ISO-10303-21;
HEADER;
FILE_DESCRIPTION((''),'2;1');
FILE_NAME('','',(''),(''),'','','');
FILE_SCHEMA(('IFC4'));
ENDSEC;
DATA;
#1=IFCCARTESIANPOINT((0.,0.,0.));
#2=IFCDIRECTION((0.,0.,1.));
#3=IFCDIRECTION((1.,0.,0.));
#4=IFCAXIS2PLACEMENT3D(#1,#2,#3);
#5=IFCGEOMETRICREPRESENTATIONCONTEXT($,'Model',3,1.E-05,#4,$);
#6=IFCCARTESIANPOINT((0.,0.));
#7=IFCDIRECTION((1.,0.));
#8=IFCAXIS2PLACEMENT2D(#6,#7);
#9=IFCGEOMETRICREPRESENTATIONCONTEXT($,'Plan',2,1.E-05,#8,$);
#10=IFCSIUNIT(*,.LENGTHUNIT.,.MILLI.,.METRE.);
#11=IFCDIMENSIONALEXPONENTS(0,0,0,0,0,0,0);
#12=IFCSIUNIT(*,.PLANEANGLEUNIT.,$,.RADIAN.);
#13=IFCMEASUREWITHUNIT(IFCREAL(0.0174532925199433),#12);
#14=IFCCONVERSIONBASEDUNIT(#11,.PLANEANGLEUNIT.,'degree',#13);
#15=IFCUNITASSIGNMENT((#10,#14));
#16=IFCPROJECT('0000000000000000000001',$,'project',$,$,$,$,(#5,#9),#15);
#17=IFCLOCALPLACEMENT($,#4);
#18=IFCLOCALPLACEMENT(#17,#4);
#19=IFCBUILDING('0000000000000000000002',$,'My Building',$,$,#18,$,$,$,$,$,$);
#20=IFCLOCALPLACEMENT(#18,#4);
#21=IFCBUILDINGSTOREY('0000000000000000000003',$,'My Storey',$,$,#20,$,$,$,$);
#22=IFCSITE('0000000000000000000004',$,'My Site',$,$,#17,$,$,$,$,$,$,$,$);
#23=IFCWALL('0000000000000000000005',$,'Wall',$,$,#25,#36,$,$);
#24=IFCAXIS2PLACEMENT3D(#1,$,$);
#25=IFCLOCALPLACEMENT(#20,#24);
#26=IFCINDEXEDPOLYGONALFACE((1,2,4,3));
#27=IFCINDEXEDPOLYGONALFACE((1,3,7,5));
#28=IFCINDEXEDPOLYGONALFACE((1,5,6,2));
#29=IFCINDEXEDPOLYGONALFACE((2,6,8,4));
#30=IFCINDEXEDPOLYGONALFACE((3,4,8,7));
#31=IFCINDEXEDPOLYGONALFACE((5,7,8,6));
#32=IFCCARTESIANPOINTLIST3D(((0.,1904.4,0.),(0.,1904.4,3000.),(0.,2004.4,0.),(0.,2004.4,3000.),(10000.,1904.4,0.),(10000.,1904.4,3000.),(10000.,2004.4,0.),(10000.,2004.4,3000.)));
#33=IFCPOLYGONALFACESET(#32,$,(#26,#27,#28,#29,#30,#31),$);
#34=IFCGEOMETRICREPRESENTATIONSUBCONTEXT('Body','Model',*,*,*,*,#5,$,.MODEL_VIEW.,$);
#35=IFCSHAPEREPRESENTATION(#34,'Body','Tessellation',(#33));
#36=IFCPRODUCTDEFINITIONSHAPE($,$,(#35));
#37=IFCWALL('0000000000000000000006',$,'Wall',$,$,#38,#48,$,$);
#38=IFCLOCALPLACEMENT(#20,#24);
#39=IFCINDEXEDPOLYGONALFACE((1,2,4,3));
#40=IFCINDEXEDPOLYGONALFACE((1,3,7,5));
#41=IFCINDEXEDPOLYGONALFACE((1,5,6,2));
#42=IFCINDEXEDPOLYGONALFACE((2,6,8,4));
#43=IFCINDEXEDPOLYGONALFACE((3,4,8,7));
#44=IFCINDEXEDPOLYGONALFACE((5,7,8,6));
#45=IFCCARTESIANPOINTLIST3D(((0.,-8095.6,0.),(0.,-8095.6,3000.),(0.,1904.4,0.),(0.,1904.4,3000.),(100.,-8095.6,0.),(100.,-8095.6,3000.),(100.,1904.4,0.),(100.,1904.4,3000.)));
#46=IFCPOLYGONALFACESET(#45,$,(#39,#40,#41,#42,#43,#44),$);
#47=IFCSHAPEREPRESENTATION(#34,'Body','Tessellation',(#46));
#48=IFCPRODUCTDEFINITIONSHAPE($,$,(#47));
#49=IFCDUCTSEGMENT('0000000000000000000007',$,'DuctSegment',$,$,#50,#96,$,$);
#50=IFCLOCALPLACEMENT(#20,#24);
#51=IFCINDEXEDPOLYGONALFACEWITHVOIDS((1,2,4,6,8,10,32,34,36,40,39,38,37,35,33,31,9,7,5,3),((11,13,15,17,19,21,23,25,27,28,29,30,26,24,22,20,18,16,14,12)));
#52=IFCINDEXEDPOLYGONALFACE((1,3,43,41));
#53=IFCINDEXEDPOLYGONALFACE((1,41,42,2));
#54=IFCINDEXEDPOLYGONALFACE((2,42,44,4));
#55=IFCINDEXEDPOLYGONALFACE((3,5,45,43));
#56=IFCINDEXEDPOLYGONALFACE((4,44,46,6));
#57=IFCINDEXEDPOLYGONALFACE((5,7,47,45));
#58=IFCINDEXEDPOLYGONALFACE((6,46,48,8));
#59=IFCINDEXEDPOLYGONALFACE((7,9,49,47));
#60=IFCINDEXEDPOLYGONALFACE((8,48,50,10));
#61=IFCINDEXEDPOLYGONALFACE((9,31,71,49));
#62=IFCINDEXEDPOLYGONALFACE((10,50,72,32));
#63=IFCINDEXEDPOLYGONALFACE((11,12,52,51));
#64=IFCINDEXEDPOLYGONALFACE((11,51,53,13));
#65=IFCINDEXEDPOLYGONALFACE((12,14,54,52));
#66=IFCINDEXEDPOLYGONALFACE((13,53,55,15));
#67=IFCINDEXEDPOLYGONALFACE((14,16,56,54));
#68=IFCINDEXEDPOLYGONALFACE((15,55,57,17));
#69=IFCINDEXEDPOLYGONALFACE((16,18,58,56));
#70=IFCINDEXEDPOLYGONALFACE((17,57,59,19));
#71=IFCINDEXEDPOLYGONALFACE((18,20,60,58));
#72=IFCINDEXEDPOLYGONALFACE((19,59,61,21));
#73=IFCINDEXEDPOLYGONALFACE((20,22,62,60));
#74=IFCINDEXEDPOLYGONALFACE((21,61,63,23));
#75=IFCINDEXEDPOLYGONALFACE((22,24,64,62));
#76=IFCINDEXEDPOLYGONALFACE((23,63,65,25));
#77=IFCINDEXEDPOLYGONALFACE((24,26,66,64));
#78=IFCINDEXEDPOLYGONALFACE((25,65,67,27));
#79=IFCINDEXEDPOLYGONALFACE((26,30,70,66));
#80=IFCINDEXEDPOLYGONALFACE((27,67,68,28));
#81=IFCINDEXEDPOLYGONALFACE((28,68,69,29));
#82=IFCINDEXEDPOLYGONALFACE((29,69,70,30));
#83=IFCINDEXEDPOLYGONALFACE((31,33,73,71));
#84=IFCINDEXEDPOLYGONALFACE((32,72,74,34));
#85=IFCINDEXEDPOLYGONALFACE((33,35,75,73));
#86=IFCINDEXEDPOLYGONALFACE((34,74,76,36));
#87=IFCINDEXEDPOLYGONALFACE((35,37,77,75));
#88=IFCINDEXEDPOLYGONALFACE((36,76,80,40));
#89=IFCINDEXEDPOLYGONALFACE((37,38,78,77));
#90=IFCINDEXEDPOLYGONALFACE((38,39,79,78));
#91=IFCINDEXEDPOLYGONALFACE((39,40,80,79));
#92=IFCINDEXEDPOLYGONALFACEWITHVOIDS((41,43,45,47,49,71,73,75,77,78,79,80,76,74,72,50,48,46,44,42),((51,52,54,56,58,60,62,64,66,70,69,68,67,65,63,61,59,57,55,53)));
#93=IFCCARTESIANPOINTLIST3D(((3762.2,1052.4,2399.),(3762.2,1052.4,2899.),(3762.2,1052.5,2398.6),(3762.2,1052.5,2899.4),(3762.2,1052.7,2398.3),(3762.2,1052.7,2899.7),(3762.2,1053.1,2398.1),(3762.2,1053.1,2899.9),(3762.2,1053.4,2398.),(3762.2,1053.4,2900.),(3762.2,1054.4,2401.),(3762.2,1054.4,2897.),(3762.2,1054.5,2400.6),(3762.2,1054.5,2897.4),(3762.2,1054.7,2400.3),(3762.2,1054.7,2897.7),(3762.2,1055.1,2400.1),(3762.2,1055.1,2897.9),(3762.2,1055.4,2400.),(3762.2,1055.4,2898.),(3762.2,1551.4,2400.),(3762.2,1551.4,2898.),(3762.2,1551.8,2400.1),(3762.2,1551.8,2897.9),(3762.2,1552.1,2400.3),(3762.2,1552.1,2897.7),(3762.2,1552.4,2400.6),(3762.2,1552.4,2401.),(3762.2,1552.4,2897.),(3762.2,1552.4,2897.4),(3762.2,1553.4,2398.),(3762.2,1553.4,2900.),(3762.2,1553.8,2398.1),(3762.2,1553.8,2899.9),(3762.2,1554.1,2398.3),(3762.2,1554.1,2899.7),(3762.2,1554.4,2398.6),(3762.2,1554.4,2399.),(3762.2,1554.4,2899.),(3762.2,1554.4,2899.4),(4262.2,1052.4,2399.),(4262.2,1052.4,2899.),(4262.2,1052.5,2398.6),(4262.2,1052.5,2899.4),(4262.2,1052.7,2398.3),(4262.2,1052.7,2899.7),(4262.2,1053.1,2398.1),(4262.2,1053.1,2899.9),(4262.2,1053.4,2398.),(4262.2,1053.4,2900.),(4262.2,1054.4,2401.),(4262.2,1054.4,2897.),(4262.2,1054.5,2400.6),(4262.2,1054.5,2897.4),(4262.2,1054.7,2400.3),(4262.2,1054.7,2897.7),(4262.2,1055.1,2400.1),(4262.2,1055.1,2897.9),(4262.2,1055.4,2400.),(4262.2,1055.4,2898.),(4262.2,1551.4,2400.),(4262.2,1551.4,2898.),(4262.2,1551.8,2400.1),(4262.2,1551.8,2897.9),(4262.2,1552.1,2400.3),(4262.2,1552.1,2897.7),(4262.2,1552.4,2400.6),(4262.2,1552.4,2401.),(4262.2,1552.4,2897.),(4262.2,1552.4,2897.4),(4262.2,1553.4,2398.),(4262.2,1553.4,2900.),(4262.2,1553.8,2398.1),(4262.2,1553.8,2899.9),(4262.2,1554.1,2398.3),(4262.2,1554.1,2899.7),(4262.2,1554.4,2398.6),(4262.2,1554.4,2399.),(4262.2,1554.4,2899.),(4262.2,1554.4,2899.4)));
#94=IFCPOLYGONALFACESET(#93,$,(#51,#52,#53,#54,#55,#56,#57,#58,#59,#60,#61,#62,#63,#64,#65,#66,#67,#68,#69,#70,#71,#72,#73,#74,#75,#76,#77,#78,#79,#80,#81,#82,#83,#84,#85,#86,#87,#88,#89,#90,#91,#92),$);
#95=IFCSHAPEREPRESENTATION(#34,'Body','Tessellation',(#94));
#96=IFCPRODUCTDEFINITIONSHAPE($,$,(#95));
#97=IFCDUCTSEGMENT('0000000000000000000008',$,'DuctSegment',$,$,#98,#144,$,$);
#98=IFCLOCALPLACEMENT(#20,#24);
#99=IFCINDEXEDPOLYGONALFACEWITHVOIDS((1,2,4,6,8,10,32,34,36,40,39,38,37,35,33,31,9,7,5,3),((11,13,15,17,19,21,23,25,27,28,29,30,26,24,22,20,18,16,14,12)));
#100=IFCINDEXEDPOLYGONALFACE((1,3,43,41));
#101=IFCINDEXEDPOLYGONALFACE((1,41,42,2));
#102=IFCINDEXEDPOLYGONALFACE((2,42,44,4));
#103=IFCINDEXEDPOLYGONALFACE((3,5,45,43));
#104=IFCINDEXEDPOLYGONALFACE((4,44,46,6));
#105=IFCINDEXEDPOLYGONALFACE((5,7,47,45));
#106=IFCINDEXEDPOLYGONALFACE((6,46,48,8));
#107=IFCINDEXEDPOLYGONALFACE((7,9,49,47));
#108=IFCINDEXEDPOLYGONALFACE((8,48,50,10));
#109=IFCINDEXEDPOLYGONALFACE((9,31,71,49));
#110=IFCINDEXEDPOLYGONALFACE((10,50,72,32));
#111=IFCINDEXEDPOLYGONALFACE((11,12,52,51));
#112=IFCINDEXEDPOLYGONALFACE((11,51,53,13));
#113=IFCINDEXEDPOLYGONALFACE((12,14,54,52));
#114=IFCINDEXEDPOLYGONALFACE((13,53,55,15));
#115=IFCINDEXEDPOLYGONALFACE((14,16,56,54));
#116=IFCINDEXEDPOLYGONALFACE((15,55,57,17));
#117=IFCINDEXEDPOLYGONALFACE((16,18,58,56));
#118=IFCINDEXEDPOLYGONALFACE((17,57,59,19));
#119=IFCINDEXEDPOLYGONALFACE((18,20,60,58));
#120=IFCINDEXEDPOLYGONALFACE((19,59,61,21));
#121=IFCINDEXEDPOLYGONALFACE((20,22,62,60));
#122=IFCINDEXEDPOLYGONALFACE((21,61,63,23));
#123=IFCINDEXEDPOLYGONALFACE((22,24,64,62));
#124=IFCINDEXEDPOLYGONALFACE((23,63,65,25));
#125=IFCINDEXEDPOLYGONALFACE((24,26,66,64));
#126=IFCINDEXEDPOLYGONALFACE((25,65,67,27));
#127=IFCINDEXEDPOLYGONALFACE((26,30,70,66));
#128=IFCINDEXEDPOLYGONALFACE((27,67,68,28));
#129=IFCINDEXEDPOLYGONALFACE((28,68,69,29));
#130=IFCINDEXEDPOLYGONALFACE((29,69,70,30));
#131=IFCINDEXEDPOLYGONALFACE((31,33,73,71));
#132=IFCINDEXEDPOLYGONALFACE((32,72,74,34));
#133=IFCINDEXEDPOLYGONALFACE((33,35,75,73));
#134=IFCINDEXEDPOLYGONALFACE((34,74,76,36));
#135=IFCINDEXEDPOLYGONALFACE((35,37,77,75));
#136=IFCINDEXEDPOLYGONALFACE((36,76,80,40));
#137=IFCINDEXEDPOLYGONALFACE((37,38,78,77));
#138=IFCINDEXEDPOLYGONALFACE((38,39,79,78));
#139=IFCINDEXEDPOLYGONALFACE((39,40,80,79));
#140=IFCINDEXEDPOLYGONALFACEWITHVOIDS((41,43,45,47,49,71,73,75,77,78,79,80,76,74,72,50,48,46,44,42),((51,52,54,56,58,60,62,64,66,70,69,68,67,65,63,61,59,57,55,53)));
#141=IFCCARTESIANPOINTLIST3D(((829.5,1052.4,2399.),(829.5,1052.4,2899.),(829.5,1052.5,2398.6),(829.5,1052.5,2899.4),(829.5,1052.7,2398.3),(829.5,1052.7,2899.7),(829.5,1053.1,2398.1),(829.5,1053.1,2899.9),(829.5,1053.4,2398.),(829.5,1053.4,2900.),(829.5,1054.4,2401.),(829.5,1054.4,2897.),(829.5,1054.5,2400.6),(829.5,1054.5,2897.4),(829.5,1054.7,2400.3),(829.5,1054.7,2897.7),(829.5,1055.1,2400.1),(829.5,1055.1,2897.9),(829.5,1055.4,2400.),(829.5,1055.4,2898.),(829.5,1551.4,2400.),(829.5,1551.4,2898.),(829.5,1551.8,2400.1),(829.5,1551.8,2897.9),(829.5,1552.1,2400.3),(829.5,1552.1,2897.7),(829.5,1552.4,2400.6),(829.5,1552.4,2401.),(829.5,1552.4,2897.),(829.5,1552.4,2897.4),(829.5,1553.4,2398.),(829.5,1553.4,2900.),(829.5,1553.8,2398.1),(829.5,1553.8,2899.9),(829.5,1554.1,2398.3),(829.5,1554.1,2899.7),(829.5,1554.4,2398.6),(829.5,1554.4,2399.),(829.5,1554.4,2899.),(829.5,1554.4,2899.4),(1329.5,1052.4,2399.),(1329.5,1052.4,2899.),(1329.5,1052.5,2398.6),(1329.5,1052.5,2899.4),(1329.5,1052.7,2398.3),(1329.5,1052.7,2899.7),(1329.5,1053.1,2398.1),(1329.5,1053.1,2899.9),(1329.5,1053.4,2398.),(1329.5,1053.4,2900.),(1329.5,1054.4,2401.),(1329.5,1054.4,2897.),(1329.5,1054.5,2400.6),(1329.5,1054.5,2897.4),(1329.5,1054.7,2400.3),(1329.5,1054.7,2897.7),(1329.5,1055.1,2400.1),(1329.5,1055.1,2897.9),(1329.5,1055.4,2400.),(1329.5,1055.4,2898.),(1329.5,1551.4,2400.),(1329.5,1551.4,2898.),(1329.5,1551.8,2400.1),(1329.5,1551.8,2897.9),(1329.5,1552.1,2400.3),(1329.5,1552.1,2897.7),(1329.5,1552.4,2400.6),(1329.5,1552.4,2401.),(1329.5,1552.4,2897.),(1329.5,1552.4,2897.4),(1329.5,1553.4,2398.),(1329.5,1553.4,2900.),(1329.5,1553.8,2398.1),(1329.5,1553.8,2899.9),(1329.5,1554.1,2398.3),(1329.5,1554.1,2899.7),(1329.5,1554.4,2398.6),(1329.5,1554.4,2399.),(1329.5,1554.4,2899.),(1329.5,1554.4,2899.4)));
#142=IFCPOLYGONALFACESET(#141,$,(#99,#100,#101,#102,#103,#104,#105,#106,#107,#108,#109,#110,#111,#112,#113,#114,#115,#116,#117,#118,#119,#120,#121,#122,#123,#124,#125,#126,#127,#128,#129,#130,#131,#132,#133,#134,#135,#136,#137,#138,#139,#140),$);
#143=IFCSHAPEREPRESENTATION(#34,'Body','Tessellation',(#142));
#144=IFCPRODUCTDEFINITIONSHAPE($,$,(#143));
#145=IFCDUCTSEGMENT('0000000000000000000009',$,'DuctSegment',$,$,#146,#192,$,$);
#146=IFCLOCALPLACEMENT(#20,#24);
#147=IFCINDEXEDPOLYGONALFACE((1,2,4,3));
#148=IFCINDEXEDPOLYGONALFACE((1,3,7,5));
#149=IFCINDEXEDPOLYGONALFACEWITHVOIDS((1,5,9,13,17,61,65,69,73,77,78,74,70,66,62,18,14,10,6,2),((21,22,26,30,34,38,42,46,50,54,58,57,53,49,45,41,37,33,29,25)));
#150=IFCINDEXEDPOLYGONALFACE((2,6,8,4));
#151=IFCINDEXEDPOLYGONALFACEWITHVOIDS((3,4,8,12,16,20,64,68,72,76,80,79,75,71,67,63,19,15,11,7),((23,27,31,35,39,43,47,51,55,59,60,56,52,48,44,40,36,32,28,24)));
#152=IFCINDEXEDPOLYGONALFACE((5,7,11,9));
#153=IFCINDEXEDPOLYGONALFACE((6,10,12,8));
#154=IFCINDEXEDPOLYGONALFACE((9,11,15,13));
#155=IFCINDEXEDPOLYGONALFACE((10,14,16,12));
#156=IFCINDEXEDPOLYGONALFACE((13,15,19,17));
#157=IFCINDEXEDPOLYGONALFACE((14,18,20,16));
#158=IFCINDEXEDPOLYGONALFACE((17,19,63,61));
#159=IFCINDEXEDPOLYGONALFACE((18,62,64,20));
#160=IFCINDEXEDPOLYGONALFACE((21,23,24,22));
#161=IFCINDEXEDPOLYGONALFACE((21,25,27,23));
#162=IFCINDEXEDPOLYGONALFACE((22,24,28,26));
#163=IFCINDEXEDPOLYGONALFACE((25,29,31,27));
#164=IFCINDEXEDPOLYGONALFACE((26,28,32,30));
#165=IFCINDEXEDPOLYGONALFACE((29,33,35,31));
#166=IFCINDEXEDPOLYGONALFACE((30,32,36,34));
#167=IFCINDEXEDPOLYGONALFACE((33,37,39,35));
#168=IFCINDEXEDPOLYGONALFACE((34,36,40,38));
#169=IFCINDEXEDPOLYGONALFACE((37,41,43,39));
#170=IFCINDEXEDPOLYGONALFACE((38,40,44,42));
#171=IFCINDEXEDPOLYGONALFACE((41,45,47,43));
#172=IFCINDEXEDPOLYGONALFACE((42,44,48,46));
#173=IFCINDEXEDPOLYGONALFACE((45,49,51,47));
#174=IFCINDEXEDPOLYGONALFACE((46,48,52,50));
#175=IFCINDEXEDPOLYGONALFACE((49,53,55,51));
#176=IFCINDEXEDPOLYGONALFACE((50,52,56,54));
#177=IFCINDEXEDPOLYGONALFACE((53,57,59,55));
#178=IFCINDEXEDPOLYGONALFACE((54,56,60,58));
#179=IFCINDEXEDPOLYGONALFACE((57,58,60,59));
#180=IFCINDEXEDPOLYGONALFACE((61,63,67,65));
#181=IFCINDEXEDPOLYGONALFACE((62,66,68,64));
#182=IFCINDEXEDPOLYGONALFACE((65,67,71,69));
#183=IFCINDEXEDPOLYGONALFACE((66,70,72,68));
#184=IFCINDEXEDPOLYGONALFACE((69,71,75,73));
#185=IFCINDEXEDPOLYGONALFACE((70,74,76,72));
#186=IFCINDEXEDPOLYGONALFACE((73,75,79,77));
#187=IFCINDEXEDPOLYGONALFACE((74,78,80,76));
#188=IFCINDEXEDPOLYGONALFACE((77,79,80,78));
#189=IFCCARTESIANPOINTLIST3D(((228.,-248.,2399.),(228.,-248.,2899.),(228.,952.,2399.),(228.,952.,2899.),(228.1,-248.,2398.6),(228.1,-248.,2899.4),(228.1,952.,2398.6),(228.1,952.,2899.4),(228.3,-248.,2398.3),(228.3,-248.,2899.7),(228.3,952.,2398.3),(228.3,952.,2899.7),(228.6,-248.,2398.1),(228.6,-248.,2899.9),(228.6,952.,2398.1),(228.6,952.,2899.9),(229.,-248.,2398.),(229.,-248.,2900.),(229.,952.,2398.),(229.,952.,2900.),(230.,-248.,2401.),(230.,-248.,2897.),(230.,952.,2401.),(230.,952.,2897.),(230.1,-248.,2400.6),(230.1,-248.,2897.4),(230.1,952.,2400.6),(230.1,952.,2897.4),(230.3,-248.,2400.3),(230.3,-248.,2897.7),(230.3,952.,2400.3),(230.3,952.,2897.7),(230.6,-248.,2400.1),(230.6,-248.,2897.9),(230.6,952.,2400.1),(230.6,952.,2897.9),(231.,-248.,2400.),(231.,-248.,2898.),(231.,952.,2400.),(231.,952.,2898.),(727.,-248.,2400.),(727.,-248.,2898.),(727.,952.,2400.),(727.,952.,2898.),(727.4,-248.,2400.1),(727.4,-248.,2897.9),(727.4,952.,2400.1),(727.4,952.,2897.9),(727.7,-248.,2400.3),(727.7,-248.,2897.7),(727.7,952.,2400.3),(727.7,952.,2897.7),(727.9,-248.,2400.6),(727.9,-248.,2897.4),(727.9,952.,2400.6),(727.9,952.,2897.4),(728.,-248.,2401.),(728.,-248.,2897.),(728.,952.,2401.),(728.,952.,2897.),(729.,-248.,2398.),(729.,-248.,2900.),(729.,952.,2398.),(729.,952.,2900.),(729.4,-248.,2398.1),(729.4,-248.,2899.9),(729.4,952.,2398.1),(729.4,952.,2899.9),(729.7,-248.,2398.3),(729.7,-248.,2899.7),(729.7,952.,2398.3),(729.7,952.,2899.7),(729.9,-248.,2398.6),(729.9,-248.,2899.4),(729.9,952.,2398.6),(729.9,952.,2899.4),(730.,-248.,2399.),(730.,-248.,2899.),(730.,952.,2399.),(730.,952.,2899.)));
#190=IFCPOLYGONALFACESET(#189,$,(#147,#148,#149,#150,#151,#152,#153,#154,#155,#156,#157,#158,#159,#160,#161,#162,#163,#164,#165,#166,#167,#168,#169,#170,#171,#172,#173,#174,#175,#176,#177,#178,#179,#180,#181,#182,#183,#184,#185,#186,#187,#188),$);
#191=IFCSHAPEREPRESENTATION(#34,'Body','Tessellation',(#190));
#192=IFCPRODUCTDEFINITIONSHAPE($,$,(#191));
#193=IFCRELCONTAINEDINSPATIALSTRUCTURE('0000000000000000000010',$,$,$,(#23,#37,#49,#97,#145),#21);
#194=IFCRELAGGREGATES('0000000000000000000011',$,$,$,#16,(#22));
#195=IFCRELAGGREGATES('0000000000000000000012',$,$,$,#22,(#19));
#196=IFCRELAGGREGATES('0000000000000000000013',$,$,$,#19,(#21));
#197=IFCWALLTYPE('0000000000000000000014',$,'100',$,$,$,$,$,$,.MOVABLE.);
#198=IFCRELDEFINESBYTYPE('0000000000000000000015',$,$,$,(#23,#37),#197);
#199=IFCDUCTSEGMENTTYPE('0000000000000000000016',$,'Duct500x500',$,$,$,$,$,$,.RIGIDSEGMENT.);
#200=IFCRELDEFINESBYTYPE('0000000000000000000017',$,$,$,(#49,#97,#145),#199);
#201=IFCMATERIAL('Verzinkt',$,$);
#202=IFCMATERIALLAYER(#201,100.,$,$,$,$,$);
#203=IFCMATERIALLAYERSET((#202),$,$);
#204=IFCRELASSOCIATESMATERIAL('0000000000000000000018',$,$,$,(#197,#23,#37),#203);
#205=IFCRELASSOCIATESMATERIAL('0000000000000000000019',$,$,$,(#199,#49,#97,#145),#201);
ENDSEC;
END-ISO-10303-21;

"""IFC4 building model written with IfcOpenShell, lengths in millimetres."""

from ifc_helpers import new_model, entity, si_unit, converted_unit, frame, origin_with_axes, origin_2d_with_axis, place, context, subcontext, project, spatial, line, indexed_curve, hollow_rectangle, outline, extrude, material, layer, layer_set, layer_usage, material_profile, profile_set, profile_usage, type_object, element, save


model = new_model("IFC4")

# Units and contexts
model_context = context("Model", 3, precision=1e-05, world=origin_with_axes())
plan_context = context("Plan", 2, precision=1e-05, world=origin_2d_with_axis())
body_context = subcontext(model_context, "Body", "Model", "MODEL_VIEW")
ifc_project = project(units=[si_unit("LENGTHUNIT", "METRE", prefix="MILLI"), converted_unit("PLANEANGLEUNIT", "degree", entity("IfcReal", 0.0174532925199433), si_unit("PLANEANGLEUNIT", "RADIAN"), dimensions=[0, 0, 0, 0, 0, 0, 0])], contexts=[model_context, plan_context])

# Site, building, storey
site_placement = place(None, origin_with_axes())
site = spatial("IfcSite", under=ifc_project, at=site_placement, Name="My Site")
building_placement = place(site_placement, origin_with_axes())
building = spatial("IfcBuilding", under=site, at=building_placement, Name="My Building")
storey_placement = place(building_placement, origin_with_axes())
storey = spatial("IfcBuildingStorey", under=building, at=storey_placement, Name="My Storey")

# Shared definitions
ifc_material = material(Name="Verzinkt")

# Walls
ifc_layer_1 = layer(ifc_material, 100.0)
ifc_layer_set_1 = layer_set([ifc_layer_1])
ifc_layer_usage_1 = layer_usage(ifc_layer_set_1, "AXIS2", "POSITIVE", 0.0)
wall_type = type_object("IfcWallType", Name="100", PredefinedType="MOVABLE", material=ifc_layer_set_1)
wall_1_placement = place(storey_placement, frame((0.0, 1904.4, 0.0), z_axis=(0.0, 0.0, 1.0), x_axis=(1.0, 0.0, 0.0)))
element("IfcWall", 1, at=wall_1_placement, inside=storey, type_object=wall_type, material=ifc_layer_usage_1, Name="Wall", context=body_context, shape_type="SweptSolid", body=[
    extrude(outline(indexed_curve([(0.0, 0.0), (0.0, 100.0), (10000.0, 100.0), (10000.0, 0.0)], segments=[line(1, 2, 3, 4, 1)])), origin_with_axes(), (0.0, 0.0, 1.0), 3000.0),
])
ifc_layer_usage_2 = layer_usage(ifc_layer_set_1, "AXIS2", "POSITIVE", 0.0)
wall_2_placement = place(storey_placement, frame((0.0, 1904.4, 0.0), z_axis=(0.0, 0.0, 1.0), x_axis=(0.0, -1.0, 0.0)))
element("IfcWall", 2, at=wall_2_placement, inside=storey, type_object=wall_type, material=ifc_layer_usage_2, Name="Wall", context=body_context, shape_type="SweptSolid", body=[
    extrude(outline(indexed_curve([(0.0, 0.0), (0.0, 100.0), (10000.0, 100.0), (10000.0, 0.0)], segments=[line(1, 2, 3, 4, 1)])), origin_with_axes(), (0.0, 0.0, 1.0), 3000.0),
])

# Duct segments
ifc_material_profile_1 = material_profile(ifc_material, hollow_rectangle(XDim=502.0, YDim=502.0, WallThickness=2.0, InnerFilletRadius=1.0, OuterFilletRadius=1.0))
ifc_profile_set_1 = profile_set([ifc_material_profile_1])
ifc_profile_usage_1 = profile_usage(ifc_profile_set_1, cardinal=5)
duct_segment_type_1 = type_object("IfcDuctSegmentType", Name="Duct500x500", PredefinedType="RIGIDSEGMENT", material=ifc_profile_set_1)
duct_segment_1_placement = place(storey_placement, frame((4262.2, 1303.4, 2649.0), z_axis=(-1.0, 0.0, 0.0), x_axis=(0.0, -1.0, 0.0)))
element("IfcDuctSegment", 3, at=duct_segment_1_placement, inside=storey, type_object=duct_segment_type_1, material=ifc_profile_usage_1, Name="DuctSegment", context=body_context, shape_type="SweptSolid", body=[
    extrude(hollow_rectangle(XDim=502.0, YDim=502.0, WallThickness=2.0, InnerFilletRadius=1.0, OuterFilletRadius=1.0), origin_with_axes(), (0.0, 0.0, 1.0), 500.0),
])
ifc_profile_usage_2 = profile_usage(ifc_profile_set_1, cardinal=5)
duct_segment_2_placement = place(storey_placement, frame((1329.5, 1303.4, 2649.0), z_axis=(-1.0, 0.0, 0.0), x_axis=(0.0, -1.0, 0.0)))
element("IfcDuctSegment", 4, at=duct_segment_2_placement, inside=storey, type_object=duct_segment_type_1, material=ifc_profile_usage_2, Name="DuctSegment", context=body_context, shape_type="SweptSolid", body=[
    extrude(hollow_rectangle(XDim=502.0, YDim=502.0, WallThickness=2.0, InnerFilletRadius=1.0, OuterFilletRadius=1.0), origin_with_axes(), (0.0, 0.0, 1.0), 500.0),
])
ifc_profile_usage_3 = profile_usage(ifc_profile_set_1, cardinal=5)
duct_segment_3_placement = place(storey_placement, frame((479.0, 952.0, 2649.0), z_axis=(0.0, -1.0, 0.0), x_axis=(1.0, 0.0, 0.0)))
element("IfcDuctSegment", 5, at=duct_segment_3_placement, inside=storey, type_object=duct_segment_type_1, material=ifc_profile_usage_3, Name="DuctSegment", context=body_context, shape_type="SweptSolid", body=[
    extrude(hollow_rectangle(XDim=502.0, YDim=502.0, WallThickness=2.0, InnerFilletRadius=1.0, OuterFilletRadius=1.0), origin_with_axes(), (0.0, 0.0, 1.0), 1200.0),
])

save(model, "model.ifc")
